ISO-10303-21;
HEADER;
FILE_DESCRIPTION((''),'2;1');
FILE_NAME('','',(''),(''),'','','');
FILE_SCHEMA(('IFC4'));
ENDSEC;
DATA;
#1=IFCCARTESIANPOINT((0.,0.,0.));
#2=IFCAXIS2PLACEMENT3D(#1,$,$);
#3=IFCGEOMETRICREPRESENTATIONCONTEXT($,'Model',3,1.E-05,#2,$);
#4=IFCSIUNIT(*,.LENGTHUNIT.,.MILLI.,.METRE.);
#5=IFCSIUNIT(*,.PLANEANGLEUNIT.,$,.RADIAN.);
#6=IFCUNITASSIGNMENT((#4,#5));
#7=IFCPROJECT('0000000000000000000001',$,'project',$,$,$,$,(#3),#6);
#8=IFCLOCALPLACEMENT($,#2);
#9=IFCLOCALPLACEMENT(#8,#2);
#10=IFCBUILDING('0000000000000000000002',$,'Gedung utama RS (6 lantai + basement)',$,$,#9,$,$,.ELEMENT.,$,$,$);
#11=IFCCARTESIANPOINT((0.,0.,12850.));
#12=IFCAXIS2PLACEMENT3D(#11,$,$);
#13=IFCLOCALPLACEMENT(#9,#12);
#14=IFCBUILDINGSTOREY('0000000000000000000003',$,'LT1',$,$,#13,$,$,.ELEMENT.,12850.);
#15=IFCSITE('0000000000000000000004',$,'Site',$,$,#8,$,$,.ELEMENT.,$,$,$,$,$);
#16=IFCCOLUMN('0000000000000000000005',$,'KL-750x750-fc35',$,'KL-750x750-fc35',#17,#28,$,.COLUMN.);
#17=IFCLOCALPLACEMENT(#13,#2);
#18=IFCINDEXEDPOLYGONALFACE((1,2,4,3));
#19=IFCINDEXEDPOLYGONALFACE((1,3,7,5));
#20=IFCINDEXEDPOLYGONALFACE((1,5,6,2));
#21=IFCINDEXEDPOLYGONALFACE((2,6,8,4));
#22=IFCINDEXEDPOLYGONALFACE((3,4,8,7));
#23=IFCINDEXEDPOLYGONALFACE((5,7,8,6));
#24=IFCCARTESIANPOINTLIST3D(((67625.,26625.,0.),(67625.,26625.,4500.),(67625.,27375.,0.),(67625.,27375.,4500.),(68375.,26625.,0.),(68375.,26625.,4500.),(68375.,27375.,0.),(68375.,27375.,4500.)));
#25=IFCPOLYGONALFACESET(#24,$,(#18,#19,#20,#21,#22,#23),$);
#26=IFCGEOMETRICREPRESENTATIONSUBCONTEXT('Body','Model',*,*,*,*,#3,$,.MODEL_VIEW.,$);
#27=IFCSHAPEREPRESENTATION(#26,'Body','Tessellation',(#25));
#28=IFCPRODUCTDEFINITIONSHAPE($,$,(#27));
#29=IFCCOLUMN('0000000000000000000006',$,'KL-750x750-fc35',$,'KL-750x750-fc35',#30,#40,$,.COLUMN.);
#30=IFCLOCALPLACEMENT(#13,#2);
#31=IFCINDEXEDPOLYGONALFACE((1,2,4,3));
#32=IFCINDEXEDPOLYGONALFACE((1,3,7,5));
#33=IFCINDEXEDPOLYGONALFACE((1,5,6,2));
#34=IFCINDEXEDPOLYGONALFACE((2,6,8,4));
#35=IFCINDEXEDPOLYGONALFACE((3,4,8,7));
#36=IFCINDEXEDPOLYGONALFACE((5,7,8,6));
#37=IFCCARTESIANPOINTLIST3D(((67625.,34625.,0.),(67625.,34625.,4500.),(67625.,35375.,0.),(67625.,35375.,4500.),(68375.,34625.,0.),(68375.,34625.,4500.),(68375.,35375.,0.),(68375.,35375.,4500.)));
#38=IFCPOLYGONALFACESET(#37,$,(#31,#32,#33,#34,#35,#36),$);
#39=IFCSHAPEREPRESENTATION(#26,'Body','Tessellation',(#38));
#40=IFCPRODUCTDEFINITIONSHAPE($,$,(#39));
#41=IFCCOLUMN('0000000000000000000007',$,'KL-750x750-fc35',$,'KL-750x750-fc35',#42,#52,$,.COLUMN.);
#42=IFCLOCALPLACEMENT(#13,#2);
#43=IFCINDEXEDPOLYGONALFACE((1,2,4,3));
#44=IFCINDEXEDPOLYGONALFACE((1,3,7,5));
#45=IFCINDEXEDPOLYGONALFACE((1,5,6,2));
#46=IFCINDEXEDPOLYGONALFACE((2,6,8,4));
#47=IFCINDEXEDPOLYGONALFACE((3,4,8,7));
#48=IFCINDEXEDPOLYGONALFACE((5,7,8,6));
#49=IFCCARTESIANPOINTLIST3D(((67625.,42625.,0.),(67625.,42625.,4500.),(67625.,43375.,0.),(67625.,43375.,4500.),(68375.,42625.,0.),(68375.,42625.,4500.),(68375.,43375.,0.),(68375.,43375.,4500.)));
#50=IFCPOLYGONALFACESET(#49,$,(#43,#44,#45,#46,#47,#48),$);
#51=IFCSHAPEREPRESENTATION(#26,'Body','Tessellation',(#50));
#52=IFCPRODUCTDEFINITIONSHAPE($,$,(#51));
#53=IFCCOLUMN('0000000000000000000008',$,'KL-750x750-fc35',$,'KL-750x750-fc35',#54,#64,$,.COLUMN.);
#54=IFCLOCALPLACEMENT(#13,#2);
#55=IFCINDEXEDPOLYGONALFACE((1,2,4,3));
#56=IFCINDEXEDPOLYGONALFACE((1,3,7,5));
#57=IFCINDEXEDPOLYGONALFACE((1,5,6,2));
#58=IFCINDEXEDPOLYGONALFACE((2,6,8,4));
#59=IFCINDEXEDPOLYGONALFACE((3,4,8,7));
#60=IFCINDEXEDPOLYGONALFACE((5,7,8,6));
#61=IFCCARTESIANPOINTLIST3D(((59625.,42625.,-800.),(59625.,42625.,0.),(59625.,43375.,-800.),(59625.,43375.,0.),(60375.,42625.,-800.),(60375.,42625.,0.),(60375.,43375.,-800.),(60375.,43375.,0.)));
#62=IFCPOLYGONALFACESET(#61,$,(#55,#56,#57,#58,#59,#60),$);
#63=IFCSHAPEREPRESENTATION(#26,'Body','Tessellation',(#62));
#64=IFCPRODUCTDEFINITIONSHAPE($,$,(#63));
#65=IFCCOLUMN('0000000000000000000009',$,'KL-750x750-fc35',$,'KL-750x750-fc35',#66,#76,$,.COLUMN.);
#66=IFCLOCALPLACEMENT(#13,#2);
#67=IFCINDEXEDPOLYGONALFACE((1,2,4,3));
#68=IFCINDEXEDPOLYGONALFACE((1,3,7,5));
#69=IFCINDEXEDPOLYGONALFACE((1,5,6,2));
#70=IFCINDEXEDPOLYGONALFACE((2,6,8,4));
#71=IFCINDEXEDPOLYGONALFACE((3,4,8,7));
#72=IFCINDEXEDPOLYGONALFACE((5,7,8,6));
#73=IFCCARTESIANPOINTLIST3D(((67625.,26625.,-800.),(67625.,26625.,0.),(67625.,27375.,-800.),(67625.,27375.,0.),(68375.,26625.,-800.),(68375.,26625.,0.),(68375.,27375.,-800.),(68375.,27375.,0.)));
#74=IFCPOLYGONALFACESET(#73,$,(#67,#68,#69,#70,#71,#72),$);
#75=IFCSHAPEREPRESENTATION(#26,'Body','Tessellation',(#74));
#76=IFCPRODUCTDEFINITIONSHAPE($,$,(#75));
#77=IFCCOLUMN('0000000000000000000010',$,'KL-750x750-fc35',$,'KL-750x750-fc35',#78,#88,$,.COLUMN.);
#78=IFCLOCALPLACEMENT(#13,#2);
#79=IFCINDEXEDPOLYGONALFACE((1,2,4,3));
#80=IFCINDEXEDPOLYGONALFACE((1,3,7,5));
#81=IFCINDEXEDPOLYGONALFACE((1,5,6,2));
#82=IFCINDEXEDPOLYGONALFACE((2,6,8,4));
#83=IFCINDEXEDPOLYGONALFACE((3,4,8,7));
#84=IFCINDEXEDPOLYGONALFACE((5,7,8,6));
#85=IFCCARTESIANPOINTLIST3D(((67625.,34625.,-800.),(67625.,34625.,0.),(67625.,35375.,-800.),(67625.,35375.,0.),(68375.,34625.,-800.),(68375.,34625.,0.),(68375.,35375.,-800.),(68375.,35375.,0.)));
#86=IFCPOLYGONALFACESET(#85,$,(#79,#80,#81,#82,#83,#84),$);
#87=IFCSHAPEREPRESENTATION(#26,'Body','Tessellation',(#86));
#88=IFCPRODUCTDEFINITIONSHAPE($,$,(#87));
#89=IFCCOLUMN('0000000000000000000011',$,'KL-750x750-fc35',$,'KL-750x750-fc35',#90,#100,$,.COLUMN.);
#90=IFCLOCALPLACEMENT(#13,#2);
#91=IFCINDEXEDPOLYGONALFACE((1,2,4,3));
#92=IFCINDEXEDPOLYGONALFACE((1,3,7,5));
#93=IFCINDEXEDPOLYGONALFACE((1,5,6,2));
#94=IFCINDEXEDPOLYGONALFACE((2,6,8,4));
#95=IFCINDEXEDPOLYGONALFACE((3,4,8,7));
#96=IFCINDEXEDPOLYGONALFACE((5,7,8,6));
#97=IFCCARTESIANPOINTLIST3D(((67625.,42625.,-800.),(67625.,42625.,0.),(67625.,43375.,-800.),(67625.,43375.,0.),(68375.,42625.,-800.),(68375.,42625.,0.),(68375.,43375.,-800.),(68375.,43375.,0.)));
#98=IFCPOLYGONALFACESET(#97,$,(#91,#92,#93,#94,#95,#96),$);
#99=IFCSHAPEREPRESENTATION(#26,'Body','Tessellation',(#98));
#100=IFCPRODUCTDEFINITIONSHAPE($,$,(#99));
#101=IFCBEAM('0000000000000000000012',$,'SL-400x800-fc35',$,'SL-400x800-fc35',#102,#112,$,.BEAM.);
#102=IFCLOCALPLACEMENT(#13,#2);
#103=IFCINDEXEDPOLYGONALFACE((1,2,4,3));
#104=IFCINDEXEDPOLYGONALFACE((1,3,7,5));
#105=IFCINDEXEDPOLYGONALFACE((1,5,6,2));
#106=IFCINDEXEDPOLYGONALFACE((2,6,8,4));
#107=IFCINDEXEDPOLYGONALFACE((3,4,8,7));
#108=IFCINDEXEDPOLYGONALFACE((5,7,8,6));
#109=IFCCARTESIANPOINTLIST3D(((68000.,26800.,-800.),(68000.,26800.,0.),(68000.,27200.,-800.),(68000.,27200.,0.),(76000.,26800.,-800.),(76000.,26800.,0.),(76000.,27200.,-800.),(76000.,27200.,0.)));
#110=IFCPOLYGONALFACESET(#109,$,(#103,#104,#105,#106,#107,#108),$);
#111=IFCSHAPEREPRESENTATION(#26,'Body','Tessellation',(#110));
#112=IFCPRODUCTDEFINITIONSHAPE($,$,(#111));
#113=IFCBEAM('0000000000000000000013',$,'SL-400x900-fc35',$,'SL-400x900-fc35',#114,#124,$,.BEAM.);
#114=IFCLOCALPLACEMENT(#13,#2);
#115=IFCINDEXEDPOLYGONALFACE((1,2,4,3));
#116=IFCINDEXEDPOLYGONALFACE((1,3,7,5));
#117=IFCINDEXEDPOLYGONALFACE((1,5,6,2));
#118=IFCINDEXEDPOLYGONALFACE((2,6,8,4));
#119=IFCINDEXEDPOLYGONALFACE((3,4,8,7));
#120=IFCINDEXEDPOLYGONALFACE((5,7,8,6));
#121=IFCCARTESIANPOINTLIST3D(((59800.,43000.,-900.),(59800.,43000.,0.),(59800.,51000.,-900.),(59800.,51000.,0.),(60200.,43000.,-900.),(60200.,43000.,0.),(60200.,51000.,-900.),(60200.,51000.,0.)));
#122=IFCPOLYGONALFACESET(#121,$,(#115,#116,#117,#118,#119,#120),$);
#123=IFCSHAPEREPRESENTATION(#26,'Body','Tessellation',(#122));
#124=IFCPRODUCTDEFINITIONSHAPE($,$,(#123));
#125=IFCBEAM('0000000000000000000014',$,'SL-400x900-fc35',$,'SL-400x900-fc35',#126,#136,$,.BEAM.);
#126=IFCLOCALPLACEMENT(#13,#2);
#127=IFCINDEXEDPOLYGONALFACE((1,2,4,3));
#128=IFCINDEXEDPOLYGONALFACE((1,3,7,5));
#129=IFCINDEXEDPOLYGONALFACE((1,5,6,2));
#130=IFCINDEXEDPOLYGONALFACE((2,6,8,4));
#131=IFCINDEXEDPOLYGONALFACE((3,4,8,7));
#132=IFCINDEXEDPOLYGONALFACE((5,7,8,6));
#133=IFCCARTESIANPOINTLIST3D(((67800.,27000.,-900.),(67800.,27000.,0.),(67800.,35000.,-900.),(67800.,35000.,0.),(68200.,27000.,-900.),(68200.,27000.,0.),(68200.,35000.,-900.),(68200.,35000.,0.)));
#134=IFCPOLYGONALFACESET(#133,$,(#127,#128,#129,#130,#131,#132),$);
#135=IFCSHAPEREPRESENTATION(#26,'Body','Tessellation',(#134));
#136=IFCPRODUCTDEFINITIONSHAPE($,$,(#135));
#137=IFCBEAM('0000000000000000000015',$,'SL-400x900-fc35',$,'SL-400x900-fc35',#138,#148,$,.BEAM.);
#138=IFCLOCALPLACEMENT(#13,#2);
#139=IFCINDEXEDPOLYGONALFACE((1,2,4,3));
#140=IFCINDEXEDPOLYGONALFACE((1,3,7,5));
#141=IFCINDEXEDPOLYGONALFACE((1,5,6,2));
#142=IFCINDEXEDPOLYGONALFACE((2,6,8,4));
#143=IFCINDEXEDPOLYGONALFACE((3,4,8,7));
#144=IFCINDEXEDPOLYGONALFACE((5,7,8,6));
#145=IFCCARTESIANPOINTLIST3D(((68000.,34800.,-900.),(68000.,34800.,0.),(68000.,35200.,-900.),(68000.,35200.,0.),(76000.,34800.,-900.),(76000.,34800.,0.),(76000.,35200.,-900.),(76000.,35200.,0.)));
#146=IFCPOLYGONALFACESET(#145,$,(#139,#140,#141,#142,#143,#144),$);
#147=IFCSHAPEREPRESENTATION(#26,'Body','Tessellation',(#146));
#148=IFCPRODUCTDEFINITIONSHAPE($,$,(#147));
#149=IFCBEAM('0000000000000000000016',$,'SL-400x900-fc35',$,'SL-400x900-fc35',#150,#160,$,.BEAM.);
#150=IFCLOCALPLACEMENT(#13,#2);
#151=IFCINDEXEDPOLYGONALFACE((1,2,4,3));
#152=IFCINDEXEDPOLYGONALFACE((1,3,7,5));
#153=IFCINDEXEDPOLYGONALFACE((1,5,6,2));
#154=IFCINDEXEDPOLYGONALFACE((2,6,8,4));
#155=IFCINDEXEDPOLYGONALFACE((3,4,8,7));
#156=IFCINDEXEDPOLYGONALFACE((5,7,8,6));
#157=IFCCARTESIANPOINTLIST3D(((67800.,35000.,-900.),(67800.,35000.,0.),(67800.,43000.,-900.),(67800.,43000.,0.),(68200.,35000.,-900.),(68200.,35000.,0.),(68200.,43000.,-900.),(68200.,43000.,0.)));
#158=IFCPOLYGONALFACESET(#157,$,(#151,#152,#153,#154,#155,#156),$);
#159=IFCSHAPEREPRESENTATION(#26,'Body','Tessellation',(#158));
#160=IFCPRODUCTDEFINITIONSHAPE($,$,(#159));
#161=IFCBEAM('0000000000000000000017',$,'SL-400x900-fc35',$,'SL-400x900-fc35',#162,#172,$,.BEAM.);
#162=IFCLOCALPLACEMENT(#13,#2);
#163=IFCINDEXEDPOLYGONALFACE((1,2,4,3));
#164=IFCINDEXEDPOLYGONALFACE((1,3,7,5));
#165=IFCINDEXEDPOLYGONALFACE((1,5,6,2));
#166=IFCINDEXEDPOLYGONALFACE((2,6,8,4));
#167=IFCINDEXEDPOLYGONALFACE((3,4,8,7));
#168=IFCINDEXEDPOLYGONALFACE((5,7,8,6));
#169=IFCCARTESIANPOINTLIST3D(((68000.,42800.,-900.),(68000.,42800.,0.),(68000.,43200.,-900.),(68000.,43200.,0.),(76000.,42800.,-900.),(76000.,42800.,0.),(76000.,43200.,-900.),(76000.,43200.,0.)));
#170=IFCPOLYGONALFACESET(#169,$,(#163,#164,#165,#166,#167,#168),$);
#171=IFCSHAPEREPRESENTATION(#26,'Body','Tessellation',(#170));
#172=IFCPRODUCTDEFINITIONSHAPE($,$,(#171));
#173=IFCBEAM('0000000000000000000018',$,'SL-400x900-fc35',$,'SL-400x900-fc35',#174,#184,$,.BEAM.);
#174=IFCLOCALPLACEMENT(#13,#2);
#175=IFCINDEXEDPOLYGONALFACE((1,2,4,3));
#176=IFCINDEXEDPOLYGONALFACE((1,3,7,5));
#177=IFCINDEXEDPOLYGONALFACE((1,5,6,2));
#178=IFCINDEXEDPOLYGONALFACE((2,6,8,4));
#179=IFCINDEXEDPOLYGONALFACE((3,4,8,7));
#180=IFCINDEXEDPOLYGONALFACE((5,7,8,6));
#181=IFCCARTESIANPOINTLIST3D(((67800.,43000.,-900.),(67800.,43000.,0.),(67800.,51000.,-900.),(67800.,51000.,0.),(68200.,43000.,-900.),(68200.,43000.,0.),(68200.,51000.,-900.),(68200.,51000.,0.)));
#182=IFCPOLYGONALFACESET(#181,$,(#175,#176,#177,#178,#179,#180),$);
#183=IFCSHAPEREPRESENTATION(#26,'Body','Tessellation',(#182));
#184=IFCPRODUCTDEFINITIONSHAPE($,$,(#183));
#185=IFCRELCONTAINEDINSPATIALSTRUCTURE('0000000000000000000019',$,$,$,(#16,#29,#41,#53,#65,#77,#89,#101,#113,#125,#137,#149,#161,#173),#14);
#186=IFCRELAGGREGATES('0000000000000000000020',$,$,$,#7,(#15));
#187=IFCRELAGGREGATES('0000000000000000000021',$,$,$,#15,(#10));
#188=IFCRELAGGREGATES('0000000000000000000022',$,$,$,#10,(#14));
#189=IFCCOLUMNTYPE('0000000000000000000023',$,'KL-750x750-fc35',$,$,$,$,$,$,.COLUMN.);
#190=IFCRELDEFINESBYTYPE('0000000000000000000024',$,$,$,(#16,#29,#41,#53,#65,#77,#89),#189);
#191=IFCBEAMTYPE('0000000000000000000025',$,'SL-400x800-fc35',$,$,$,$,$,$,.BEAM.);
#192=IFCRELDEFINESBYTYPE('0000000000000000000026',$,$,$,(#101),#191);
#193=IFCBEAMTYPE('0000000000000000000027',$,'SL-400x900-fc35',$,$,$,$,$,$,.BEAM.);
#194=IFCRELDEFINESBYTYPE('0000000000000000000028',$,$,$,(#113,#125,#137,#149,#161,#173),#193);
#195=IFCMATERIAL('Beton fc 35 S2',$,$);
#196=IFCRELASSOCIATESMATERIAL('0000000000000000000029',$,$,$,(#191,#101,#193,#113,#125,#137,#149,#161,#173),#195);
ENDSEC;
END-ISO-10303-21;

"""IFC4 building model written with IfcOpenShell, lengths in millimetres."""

from ifc_helpers import new_model, si_unit, frame, origin, origin_2d, place, context, subcontext, project, spatial, rectangle, extrude, material, material_profile, profile_set, profile_usage, type_object, element, save


model = new_model("IFC4")

# Units and contexts
model_context = context("Model", 3, precision=1e-05, world=origin())
body_context = subcontext(model_context, "Body", "Model", "MODEL_VIEW")
ifc_project = project(units=[si_unit("LENGTHUNIT", "METRE", prefix="MILLI"), si_unit("PLANEANGLEUNIT", "RADIAN")], contexts=[model_context])

# Site, building, storey
site_placement = place(None, origin())
site = spatial("IfcSite", under=ifc_project, at=site_placement, Name="Site", CompositionType="ELEMENT")
building_placement = place(site_placement, origin())
building = spatial("IfcBuilding", under=site, at=building_placement, Name="Gedung utama RS (6 lantai + basement)", CompositionType="ELEMENT")
storey_placement = place(building_placement, frame((0.0, 0.0, 12850.0)))
storey = spatial("IfcBuildingStorey", under=building, at=storey_placement, Name="LT1", CompositionType="ELEMENT", Elevation=12850.0)

# Columns
ifc_material_profile_1 = material_profile(None, rectangle(XDim=750.0, YDim=750.0, at=origin_2d()), Name="KL-750x750-fc35")
ifc_profile_set_1 = profile_set([ifc_material_profile_1], Name="KL-750x750-fc35")
ifc_profile_usage_1 = profile_usage(ifc_profile_set_1, cardinal=5)
column_type = type_object("IfcColumnType", Name="KL-750x750-fc35", PredefinedType="COLUMN", material=ifc_profile_set_1)
for number, where, z_axis, x_axis, name in (
    (1, (68000.0, 27000.0, 0.0), (0.0, 0.0, 1.0), (1.0, 0.0, 0.0), "KL-750x750-fc35"),
    (2, (68000.0, 35000.0, 0.0), (0.0, 0.0, 1.0), (1.0, 0.0, 0.0), "KL-750x750-fc35"),
    (3, (68000.0, 43000.0, 0.0), (0.0, 0.0, 1.0), (1.0, 0.0, 0.0), "KL-750x750-fc35"),
):
    element("IfcColumn", number, at=place(storey_placement, frame(where, z_axis=z_axis, x_axis=x_axis)), inside=storey, type_object=column_type, material=ifc_profile_usage_1, Name=name, ObjectType="KL-750x750-fc35", PredefinedType="COLUMN", context=body_context, shape_type="SweptSolid", body=[
        extrude(rectangle(XDim=750.0, YDim=750.0, at=origin_2d()), origin(), (0.0, 0.0, 1.0), 4500.0),
    ])
for number, where, z_axis, x_axis, name in (
    (4, (60000.0, 43000.0, -800.0), (0.0, 0.0, 1.0), (1.0, 0.0, 0.0), "KL-750x750-fc35"),
    (5, (68000.0, 27000.0, -800.0), (0.0, 0.0, 1.0), (1.0, 0.0, 0.0), "KL-750x750-fc35"),
    (6, (68000.0, 35000.0, -800.0), (0.0, 0.0, 1.0), (1.0, 0.0, 0.0), "KL-750x750-fc35"),
    (7, (68000.0, 43000.0, -800.0), (0.0, 0.0, 1.0), (1.0, 0.0, 0.0), "KL-750x750-fc35"),
):
    element("IfcColumn", number, at=place(storey_placement, frame(where, z_axis=z_axis, x_axis=x_axis)), inside=storey, type_object=column_type, material=ifc_profile_usage_1, Name=name, ObjectType="KL-750x750-fc35", PredefinedType="COLUMN", context=body_context, shape_type="SweptSolid", body=[
        extrude(rectangle(XDim=750.0, YDim=750.0, at=origin_2d()), origin(), (0.0, 0.0, 1.0), 800.0),
    ])

# Beams
ifc_material = material(Name="Beton fc 35 S2")
ifc_material_profile_2 = material_profile(ifc_material, rectangle(XDim=400.0, YDim=800.0, at=origin_2d()), Name="SL-400x800-fc35")
ifc_profile_set_2 = profile_set([ifc_material_profile_2], Name="SL-400x800-fc35")
ifc_profile_usage_2 = profile_usage(ifc_profile_set_2, cardinal=8)
beam_type_1 = type_object("IfcBeamType", Name="SL-400x800-fc35", PredefinedType="BEAM", material=ifc_profile_set_2)
beam_1_placement = place(storey_placement, frame((68000.0, 27000.0, -400.0)))
element("IfcBeam", 8, at=beam_1_placement, inside=storey, type_object=beam_type_1, material=ifc_profile_usage_2, Name="SL-400x800-fc35", ObjectType="SL-400x800-fc35", PredefinedType="BEAM", context=body_context, shape_type="SweptSolid", body=[
    extrude(rectangle(XDim=400.0, YDim=800.0, at=origin_2d()), frame((0.0, 0.0, 0.0), z_axis=(1.0, 0.0, 0.0), x_axis=(0.0, 1.0, 0.0)), (0.0, 0.0, 1.0), 8000.0),
])
ifc_material_profile_3 = material_profile(ifc_material, rectangle(XDim=400.0, YDim=900.0, at=origin_2d()), Name="SL-400x900-fc35")
ifc_profile_set_3 = profile_set([ifc_material_profile_3], Name="SL-400x900-fc35")
ifc_profile_usage_3 = profile_usage(ifc_profile_set_3, cardinal=8)
beam_type_2 = type_object("IfcBeamType", Name="SL-400x900-fc35", PredefinedType="BEAM", material=ifc_profile_set_3)
for number, where, name in (
    (9, (60000.0, 43000.0, -450.0), "SL-400x900-fc35"),
    (10, (68000.0, 27000.0, -450.0), "SL-400x900-fc35"),
):
    element("IfcBeam", number, at=place(storey_placement, frame(where)), inside=storey, type_object=beam_type_2, material=ifc_profile_usage_3, Name=name, ObjectType="SL-400x900-fc35", PredefinedType="BEAM", context=body_context, shape_type="SweptSolid", body=[
        extrude(rectangle(XDim=400.0, YDim=900.0, at=origin_2d()), frame((0.0, 0.0, 0.0), z_axis=(0.0, 1.0, 0.0), x_axis=(-1.0, 0.0, 0.0)), (0.0, 0.0, 1.0), 8000.0),
    ])
beam_2_placement = place(storey_placement, frame((68000.0, 35000.0, -450.0)))
element("IfcBeam", 11, at=beam_2_placement, inside=storey, type_object=beam_type_2, material=ifc_profile_usage_3, Name="SL-400x900-fc35", ObjectType="SL-400x900-fc35", PredefinedType="BEAM", context=body_context, shape_type="SweptSolid", body=[
    extrude(rectangle(XDim=400.0, YDim=900.0, at=origin_2d()), frame((0.0, 0.0, 0.0), z_axis=(1.0, 0.0, 0.0), x_axis=(0.0, 1.0, 0.0)), (0.0, 0.0, 1.0), 8000.0),
])
beam_3_placement = place(storey_placement, frame((68000.0, 35000.0, -450.0)))
element("IfcBeam", 12, at=beam_3_placement, inside=storey, type_object=beam_type_2, material=ifc_profile_usage_3, Name="SL-400x900-fc35", ObjectType="SL-400x900-fc35", PredefinedType="BEAM", context=body_context, shape_type="SweptSolid", body=[
    extrude(rectangle(XDim=400.0, YDim=900.0, at=origin_2d()), frame((0.0, 0.0, 0.0), z_axis=(0.0, 1.0, 0.0), x_axis=(-1.0, 0.0, 0.0)), (0.0, 0.0, 1.0), 8000.0),
])
beam_4_placement = place(storey_placement, frame((68000.0, 43000.0, -450.0)))
element("IfcBeam", 13, at=beam_4_placement, inside=storey, type_object=beam_type_2, material=ifc_profile_usage_3, Name="SL-400x900-fc35", ObjectType="SL-400x900-fc35", PredefinedType="BEAM", context=body_context, shape_type="SweptSolid", body=[
    extrude(rectangle(XDim=400.0, YDim=900.0, at=origin_2d()), frame((0.0, 0.0, 0.0), z_axis=(1.0, 0.0, 0.0), x_axis=(0.0, 1.0, 0.0)), (0.0, 0.0, 1.0), 8000.0),
])
beam_5_placement = place(storey_placement, frame((68000.0, 43000.0, -450.0)))
element("IfcBeam", 14, at=beam_5_placement, inside=storey, type_object=beam_type_2, material=ifc_profile_usage_3, Name="SL-400x900-fc35", ObjectType="SL-400x900-fc35", PredefinedType="BEAM", context=body_context, shape_type="SweptSolid", body=[
    extrude(rectangle(XDim=400.0, YDim=900.0, at=origin_2d()), frame((0.0, 0.0, 0.0), z_axis=(0.0, 1.0, 0.0), x_axis=(-1.0, 0.0, 0.0)), (0.0, 0.0, 1.0), 8000.0),
])

save(model, "model.ifc")
